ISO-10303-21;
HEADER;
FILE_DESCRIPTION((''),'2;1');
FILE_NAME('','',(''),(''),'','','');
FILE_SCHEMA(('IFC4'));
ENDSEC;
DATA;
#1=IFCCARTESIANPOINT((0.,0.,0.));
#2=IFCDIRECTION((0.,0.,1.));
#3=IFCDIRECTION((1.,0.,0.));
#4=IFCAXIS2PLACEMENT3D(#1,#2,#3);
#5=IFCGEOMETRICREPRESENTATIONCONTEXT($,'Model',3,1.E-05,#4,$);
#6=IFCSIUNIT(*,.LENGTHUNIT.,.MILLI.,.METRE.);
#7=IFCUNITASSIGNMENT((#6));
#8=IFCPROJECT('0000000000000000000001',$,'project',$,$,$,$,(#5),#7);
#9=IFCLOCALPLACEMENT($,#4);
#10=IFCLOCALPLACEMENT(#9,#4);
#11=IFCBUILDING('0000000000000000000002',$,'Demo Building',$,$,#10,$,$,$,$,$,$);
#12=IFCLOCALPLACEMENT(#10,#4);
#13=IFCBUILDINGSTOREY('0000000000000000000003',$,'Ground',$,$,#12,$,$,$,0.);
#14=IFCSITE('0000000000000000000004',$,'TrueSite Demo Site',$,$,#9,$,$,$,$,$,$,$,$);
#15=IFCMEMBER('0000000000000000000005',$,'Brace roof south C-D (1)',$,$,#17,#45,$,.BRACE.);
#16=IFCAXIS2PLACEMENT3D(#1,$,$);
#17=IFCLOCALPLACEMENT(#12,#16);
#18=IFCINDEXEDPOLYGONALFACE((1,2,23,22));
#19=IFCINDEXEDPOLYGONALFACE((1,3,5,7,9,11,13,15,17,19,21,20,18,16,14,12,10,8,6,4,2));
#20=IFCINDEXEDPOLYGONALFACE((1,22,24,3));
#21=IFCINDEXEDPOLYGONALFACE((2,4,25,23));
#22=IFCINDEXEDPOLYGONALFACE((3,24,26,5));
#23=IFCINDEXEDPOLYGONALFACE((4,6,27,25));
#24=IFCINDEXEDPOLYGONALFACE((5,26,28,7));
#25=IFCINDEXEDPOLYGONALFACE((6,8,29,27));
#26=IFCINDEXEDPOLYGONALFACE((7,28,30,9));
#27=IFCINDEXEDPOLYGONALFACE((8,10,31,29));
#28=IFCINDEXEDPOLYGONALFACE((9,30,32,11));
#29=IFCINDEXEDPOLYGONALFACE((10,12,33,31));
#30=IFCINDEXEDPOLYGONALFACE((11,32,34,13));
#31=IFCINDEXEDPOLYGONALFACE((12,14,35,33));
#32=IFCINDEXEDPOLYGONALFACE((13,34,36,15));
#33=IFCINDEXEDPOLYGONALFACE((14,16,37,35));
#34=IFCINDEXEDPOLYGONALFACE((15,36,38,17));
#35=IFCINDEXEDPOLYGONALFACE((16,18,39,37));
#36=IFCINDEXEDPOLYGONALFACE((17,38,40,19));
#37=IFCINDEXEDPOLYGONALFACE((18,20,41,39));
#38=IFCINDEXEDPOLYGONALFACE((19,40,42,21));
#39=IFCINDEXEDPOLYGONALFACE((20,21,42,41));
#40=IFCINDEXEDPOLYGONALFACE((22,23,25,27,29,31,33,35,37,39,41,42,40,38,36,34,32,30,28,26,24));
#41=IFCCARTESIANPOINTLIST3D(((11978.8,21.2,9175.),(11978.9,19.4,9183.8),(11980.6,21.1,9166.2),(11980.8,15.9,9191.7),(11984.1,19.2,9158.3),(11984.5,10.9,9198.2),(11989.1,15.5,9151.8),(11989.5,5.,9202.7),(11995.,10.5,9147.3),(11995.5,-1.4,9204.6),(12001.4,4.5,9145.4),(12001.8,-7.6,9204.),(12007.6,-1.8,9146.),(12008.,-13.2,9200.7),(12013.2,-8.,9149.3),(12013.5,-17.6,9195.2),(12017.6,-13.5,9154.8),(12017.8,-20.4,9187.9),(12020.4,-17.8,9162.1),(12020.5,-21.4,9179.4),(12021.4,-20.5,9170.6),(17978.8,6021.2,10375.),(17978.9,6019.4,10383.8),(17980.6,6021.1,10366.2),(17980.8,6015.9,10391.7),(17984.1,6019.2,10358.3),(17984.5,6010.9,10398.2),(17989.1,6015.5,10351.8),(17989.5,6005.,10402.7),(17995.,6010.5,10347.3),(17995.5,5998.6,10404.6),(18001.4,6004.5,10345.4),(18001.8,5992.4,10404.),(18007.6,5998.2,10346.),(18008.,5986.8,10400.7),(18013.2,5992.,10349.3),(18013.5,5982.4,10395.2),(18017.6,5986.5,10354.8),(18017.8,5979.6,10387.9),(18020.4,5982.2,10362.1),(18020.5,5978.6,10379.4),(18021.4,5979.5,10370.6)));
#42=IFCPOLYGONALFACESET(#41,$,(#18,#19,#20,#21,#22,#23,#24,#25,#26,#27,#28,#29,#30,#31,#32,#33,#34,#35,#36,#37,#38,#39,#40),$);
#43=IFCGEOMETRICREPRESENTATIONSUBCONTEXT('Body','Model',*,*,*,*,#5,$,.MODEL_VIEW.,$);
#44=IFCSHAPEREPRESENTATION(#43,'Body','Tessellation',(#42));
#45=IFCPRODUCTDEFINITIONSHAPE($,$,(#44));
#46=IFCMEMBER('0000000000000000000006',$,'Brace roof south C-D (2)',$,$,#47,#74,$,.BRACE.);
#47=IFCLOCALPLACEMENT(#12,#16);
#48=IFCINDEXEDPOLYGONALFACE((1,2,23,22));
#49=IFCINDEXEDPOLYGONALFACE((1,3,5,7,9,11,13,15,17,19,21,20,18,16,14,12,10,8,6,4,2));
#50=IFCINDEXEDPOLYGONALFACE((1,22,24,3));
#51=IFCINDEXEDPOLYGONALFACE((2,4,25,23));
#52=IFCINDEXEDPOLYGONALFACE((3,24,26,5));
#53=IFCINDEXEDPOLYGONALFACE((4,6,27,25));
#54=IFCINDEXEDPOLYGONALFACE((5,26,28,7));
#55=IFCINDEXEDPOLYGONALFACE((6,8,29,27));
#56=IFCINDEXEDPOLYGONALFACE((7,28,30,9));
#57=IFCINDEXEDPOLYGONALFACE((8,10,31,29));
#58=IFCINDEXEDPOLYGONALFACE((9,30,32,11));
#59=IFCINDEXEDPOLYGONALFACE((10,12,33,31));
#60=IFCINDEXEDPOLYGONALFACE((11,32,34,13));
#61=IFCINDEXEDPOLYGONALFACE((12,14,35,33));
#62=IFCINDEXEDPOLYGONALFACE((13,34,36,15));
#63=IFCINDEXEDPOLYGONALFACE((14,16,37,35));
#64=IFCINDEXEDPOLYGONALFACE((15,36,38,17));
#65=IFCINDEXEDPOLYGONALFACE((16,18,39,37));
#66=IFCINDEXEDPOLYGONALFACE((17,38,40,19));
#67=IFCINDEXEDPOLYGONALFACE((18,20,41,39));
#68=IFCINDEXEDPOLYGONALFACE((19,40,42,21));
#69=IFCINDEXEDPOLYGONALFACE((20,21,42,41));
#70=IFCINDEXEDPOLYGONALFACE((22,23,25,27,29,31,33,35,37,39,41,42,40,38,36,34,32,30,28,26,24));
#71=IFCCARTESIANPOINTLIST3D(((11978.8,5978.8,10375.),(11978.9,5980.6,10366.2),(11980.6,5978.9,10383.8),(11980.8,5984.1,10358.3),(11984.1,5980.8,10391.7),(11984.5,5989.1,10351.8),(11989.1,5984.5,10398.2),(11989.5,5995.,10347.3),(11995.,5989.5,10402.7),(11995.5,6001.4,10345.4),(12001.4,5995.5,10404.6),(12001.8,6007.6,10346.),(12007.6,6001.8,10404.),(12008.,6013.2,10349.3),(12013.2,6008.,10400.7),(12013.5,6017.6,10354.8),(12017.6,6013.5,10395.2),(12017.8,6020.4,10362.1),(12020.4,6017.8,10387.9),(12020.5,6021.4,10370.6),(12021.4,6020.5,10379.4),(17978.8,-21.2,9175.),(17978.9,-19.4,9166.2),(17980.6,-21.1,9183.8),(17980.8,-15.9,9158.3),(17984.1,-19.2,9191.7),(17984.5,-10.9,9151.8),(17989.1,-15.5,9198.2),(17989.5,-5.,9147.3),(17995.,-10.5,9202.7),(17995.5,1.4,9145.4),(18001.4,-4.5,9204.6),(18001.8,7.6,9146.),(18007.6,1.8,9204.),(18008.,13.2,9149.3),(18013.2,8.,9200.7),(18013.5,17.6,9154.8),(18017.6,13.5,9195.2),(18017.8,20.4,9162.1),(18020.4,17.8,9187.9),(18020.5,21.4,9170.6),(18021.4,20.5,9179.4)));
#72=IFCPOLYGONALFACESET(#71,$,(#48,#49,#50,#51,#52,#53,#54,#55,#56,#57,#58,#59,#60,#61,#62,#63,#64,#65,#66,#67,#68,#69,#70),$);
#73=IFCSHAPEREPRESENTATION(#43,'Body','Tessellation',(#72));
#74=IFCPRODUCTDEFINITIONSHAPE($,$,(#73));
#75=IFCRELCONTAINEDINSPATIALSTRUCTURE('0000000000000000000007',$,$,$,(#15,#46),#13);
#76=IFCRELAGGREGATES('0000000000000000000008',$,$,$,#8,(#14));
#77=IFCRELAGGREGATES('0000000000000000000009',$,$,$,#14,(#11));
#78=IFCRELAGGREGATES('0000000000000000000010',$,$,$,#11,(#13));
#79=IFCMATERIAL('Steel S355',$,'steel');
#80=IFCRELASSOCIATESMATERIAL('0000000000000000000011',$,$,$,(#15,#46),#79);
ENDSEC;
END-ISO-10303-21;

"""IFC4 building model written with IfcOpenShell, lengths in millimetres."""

from ifc_helpers import new_model, si_unit, frame, origin_with_axes, place, context, subcontext, project, spatial, circle, extrude, material, element, save


model = new_model("IFC4")

# Units and contexts
model_context = context("Model", 3, precision=1e-05, world=origin_with_axes())
body_context = subcontext(model_context, "Body", "Model", "MODEL_VIEW")
ifc_project = project(units=[si_unit("LENGTHUNIT", "METRE", prefix="MILLI")], contexts=[model_context])

# Site, building, storey
site_placement = place(None, origin_with_axes())
site = spatial("IfcSite", under=ifc_project, at=site_placement, Name="TrueSite Demo Site")
building_placement = place(site_placement, origin_with_axes())
building = spatial("IfcBuilding", under=site, at=building_placement, Name="Demo Building")
storey_placement = place(building_placement, origin_with_axes())
storey = spatial("IfcBuildingStorey", under=building, at=storey_placement, Name="Ground", Elevation=0.0)

# Shared definitions
ifc_material_1 = material(Name="Steel S355", Category="steel")

# Members
for number, where, z_axis, x_axis, name in (
    (1, (12000.0, 0.0, 9175.0), (0.70014, 0.70014, 0.140028), (-0.707107, 0.707107, 0.0), "Brace roof south C-D (1)"),
    (2, (18000.0, 0.0, 9175.0), (-0.70014, 0.70014, 0.140028), (-0.707107, -0.707107, 0.0), "Brace roof south C-D (2)"),
):
    element("IfcMember", number, at=place(storey_placement, frame(where, z_axis=z_axis, x_axis=x_axis)), inside=storey, material=ifc_material_1, Name=name, PredefinedType="BRACE", context=body_context, shape_type="SweptSolid", body=[
        extrude(circle(Radius=30.0), origin_with_axes(), (0.0, 0.0, 1.0), 8569.7),
    ])

save(model, "model.ifc")
